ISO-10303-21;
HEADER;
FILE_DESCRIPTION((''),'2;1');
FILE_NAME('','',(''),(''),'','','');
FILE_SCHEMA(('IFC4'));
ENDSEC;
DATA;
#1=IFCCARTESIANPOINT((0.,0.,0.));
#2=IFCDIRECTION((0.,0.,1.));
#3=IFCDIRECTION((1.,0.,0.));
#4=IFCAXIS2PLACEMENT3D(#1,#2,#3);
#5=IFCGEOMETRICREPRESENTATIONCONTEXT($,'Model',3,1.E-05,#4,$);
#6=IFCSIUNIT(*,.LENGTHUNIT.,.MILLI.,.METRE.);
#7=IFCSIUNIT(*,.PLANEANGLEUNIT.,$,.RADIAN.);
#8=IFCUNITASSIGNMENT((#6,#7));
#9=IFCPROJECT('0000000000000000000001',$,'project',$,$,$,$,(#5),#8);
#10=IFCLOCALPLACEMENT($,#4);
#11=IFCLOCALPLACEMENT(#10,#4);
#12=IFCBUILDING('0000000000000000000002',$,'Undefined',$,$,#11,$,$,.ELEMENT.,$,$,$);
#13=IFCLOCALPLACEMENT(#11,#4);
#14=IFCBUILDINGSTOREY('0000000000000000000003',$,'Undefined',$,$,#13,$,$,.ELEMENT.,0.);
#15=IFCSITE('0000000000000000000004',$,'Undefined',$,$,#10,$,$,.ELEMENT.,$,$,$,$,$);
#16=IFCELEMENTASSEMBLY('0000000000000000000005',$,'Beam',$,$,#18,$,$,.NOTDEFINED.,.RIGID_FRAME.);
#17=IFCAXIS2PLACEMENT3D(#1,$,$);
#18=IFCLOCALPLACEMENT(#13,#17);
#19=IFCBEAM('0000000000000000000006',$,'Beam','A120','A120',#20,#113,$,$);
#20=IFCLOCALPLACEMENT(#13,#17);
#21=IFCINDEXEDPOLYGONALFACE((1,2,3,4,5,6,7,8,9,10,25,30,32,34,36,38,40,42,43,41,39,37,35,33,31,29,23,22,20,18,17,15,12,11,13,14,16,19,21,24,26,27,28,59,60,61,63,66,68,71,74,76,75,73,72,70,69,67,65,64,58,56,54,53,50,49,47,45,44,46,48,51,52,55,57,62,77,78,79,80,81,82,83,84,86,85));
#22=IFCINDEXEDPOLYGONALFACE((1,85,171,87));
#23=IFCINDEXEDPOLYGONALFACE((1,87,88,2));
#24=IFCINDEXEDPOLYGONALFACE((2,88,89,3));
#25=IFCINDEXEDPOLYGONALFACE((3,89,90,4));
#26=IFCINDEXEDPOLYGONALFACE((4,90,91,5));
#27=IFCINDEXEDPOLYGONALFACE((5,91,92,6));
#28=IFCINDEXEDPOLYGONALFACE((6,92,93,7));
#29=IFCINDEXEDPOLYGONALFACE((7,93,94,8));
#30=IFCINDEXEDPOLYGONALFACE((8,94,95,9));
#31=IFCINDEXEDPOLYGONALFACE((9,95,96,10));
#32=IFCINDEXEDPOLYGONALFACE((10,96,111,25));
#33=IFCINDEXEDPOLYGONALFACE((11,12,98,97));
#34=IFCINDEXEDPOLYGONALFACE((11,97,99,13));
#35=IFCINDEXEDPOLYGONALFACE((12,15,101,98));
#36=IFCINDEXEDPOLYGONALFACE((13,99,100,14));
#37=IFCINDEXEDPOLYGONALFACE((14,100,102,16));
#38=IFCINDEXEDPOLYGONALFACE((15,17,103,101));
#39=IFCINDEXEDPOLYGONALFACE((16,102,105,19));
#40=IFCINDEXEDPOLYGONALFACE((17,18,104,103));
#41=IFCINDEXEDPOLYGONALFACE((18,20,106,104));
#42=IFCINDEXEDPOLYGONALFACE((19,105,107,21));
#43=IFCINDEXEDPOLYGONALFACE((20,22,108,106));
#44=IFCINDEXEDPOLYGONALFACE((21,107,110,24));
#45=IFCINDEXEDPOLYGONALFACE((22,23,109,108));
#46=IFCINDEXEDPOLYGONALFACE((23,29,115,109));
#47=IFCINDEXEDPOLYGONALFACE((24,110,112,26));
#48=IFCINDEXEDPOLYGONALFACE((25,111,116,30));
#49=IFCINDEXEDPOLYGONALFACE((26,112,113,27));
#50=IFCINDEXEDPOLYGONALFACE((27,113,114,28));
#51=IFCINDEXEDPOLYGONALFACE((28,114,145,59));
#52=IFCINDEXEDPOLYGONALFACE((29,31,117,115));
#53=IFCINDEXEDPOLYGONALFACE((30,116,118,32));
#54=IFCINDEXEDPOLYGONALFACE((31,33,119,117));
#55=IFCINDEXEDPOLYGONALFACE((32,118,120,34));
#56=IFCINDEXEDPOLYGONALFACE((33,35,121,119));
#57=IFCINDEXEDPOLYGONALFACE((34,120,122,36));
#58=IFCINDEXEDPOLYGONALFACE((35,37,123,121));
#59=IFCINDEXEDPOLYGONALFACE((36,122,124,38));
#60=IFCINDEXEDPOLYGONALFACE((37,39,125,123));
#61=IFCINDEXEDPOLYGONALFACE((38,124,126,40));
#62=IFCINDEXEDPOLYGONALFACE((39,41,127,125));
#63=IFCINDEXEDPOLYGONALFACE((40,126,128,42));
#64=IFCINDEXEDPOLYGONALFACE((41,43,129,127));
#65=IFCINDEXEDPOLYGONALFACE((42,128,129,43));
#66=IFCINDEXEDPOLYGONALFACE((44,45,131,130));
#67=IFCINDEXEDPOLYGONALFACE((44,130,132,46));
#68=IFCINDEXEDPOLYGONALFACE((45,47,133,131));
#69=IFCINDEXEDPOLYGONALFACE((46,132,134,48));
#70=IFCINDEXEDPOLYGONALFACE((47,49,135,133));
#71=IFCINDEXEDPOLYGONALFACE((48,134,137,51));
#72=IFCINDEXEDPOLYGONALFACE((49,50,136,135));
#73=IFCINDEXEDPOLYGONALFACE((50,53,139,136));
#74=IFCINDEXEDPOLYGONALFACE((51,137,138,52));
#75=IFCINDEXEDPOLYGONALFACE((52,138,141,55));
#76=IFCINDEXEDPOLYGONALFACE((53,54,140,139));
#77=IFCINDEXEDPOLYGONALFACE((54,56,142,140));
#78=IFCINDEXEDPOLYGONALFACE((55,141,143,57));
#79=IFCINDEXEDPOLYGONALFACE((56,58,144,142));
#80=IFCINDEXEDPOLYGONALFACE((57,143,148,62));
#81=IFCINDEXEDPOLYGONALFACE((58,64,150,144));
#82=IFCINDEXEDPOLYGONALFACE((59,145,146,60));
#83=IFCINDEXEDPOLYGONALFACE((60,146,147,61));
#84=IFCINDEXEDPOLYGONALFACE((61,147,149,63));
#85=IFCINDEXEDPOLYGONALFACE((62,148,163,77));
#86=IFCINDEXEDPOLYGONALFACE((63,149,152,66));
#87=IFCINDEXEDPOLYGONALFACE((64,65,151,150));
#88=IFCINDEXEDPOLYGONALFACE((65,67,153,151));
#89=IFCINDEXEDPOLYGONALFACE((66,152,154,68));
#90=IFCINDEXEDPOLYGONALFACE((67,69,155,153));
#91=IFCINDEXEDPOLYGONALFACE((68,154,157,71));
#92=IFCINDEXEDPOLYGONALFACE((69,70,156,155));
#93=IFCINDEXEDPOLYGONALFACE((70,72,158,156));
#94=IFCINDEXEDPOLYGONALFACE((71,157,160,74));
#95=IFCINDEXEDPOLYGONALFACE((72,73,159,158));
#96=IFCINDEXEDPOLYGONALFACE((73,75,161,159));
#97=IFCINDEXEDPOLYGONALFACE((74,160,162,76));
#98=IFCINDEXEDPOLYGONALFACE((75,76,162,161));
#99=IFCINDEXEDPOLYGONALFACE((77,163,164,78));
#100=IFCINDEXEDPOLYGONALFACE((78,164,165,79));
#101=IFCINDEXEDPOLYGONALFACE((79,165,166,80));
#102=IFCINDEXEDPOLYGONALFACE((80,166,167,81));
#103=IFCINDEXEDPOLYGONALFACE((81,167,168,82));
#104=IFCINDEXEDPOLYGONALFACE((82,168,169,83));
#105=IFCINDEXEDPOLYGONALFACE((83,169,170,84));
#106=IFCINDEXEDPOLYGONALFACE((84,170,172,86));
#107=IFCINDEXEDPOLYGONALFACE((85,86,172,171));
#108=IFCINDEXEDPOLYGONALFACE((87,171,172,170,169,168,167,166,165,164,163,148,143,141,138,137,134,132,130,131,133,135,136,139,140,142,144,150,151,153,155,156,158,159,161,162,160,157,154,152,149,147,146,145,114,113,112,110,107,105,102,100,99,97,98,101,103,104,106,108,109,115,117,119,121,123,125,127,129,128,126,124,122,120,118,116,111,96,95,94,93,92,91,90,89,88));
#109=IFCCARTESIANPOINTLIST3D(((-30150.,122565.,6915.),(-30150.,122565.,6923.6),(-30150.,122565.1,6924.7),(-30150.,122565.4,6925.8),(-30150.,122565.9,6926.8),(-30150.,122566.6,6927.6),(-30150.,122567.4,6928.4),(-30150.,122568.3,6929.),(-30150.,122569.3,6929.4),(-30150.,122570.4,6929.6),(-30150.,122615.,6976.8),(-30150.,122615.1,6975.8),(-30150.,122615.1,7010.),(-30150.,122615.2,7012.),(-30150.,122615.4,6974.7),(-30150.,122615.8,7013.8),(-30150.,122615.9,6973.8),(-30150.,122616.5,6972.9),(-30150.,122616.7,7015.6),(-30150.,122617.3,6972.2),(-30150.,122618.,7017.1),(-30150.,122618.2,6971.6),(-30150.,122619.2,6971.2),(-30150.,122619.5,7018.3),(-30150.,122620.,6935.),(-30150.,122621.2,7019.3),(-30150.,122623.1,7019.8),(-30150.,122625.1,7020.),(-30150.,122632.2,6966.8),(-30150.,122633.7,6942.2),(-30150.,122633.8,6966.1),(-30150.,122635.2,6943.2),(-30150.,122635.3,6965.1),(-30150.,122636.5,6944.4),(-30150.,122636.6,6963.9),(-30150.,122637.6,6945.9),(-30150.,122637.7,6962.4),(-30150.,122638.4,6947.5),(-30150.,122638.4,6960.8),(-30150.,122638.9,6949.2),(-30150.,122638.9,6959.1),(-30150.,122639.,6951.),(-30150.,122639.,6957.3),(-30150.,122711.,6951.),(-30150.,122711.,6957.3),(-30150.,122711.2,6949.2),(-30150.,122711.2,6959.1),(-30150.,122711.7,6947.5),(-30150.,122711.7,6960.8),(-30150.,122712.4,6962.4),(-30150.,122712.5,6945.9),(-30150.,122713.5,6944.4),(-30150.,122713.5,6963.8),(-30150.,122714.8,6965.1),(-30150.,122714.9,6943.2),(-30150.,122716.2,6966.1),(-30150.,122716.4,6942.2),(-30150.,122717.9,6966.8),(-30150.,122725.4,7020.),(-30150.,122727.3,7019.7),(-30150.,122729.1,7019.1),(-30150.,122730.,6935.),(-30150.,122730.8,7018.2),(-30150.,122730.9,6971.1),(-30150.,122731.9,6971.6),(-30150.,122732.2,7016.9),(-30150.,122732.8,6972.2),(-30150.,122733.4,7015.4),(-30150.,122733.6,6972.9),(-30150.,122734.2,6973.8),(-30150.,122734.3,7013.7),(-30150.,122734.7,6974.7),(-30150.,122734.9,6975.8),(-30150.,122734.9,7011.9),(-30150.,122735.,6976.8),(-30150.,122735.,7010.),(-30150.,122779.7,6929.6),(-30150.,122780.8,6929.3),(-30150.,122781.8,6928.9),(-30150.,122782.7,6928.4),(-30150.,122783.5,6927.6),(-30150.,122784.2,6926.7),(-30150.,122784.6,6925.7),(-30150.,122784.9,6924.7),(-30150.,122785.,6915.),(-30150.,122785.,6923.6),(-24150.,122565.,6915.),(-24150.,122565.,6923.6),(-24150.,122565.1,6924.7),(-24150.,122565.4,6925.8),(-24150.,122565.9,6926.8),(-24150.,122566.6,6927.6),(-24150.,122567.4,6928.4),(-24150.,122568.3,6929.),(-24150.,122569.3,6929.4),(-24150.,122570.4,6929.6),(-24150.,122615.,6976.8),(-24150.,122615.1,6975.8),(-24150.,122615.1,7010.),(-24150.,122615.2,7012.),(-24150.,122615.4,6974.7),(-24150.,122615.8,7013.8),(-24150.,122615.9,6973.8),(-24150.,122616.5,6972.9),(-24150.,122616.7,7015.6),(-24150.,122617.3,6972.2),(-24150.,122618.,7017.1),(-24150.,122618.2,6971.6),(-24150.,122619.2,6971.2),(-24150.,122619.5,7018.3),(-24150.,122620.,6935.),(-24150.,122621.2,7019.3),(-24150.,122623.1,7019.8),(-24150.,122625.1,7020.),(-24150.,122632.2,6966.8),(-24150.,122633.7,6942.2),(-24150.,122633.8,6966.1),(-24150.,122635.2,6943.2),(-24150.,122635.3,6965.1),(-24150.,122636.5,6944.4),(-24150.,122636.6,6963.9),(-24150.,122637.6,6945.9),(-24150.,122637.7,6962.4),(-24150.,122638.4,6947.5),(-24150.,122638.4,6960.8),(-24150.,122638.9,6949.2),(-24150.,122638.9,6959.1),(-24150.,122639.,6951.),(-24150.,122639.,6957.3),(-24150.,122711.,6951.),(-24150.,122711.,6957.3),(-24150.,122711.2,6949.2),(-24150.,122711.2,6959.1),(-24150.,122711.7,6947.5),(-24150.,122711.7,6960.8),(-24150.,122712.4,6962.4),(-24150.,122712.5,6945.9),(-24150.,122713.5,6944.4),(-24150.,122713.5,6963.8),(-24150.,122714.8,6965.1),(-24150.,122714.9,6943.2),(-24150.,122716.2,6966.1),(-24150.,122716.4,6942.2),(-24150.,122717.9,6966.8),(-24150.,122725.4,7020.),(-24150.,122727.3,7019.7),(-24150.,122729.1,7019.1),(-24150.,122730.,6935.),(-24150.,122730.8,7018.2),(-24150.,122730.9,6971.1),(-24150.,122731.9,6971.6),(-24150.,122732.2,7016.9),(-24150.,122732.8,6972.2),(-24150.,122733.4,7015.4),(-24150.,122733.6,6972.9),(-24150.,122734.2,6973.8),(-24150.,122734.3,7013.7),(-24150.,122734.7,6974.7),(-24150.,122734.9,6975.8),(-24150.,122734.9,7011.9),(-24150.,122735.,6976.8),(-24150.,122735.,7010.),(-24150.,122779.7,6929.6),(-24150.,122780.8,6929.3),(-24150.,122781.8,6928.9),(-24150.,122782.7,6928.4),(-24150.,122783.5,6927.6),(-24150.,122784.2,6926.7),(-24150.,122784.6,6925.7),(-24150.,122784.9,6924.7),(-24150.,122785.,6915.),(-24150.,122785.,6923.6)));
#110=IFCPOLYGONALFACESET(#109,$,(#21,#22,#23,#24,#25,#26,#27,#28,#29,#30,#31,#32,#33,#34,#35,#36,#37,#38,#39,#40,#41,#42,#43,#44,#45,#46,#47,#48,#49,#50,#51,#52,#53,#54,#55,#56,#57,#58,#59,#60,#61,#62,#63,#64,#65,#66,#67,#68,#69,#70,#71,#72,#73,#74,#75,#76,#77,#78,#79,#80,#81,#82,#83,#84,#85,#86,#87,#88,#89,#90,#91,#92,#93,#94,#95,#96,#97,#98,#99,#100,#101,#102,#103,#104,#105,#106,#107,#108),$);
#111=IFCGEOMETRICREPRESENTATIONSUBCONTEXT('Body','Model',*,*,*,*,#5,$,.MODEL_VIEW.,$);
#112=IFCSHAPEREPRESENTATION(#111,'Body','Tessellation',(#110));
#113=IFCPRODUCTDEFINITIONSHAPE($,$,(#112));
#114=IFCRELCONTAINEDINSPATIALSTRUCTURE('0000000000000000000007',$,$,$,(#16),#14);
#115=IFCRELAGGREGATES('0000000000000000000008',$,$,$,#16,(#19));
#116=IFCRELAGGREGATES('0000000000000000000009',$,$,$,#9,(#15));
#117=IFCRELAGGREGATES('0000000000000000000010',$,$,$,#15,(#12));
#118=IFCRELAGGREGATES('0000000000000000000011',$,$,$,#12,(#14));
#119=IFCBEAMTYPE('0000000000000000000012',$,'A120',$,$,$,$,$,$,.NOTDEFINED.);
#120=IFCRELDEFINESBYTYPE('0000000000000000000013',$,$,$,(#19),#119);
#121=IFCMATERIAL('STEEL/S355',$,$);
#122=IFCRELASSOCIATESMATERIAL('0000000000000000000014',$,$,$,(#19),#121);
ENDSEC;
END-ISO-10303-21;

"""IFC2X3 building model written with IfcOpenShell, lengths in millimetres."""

from ifc_helpers import new_model, si_unit, frame, origin_with_axes, place, context, subcontext, project, spatial, polyline, outline, extrude, material, type_object, element, aggregate, save


model = new_model("IFC2X3")

# Units and contexts
model_context = context("Model", 3, precision=1e-05, world=origin_with_axes())
body_context = subcontext(model_context, "Body", "Model", "MODEL_VIEW")
ifc_project = project(units=[si_unit("LENGTHUNIT", "METRE", prefix="MILLI"), si_unit("PLANEANGLEUNIT", "RADIAN")], contexts=[model_context])

# Site, building, storey
site_placement = place(None, origin_with_axes())
site = spatial("IfcSite", under=ifc_project, at=site_placement, Name="Undefined", CompositionType="ELEMENT")
building_placement = place(site_placement, origin_with_axes())
building = spatial("IfcBuilding", under=site, at=building_placement, Name="Undefined", CompositionType="ELEMENT")
storey_placement = place(building_placement, origin_with_axes())
storey = spatial("IfcBuildingStorey", under=building, at=storey_placement, Name="Undefined", CompositionType="ELEMENT", Elevation=0.0)

# Element assembly, beam
ifc_material_1 = material(Name="STEEL/S355")
beam_type_1 = type_object("IfcBeamType", Name="A120", PredefinedType="NOTDEFINED")
assembly_1_placement = place(storey_placement, origin_with_axes())
assembly_1 = element("IfcElementAssembly", 1, at=assembly_1_placement, inside=storey, Name="Beam", AssemblyPlace="NOTDEFINED", PredefinedType="RIGID_FRAME")
beam_1_placement = place(assembly_1_placement, frame((-30150.0, 122675.0, 6967.5), z_axis=(0.0, 0.000118, 1.0), x_axis=(1.0, 0.0, 0.0)))
beam_1 = element("IfcBeam", 2, at=beam_1_placement, type_object=beam_type_1, material=ifc_material_1, Name="Beam", Description="A120", ObjectType="A120", context=body_context, shape_type="SweptSolid", body=[
    extrude(outline(polyline([(-110.0, -52.5), (-110.0, -43.9), (-109.9, -42.8), (-109.6, -41.8), (-109.1, -40.8), (-108.5, -39.9), (-107.7, -39.1), (-106.7, -38.6), (-105.7, -38.2), (-104.7, -37.9), (-55.0, -32.5), (-41.3, -25.3), (-39.8, -24.3), (-38.5, -23.1), (-37.4, -21.6), (-36.6, -20.0), (-36.2, -18.3), (-36.0, -16.5), (-36.0, -10.2), (-36.1, -8.4), (-36.6, -6.7), (-37.4, -5.1), (-38.4, -3.7), (-39.7, -2.4), (-41.2, -1.4), (-42.8, -0.7), (-55.9, 3.6), (-56.9, 4.1), (-57.8, 4.7), (-58.5, 5.4), (-59.2, 6.3), (-59.6, 7.2), (-59.9, 8.3), (-60.0, 9.3), (-60.0, 42.5), (-59.8, 44.4), (-59.3, 46.2), (-58.4, 47.9), (-57.2, 49.4), (-55.7, 50.7), (-54.1, 51.6), (-52.3, 52.2), (-50.4, 52.5), (50.0, 52.5), (51.9, 52.3), (53.8, 51.7), (55.5, 50.8), (57.1, 49.6), (58.3, 48.1), (59.2, 46.3), (59.8, 44.4), (60.0, 42.5), (60.0, 9.3), (59.9, 8.3), (59.6, 7.2), (59.2, 6.3), (58.5, 5.4), (57.8, 4.7), (56.9, 4.1), (55.9, 3.6), (42.8, -0.7), (41.2, -1.4), (39.7, -2.4), (38.4, -3.7), (37.4, -5.1), (36.6, -6.7), (36.1, -8.4), (36.0, -10.2), (36.0, -16.5), (36.2, -18.3), (36.6, -20.0), (37.4, -21.6), (38.5, -23.1), (39.8, -24.3), (41.3, -25.3), (55.0, -32.5), (104.7, -37.9), (105.7, -38.2), (106.7, -38.6), (107.7, -39.1), (108.5, -39.9), (109.1, -40.8), (109.6, -41.8), (109.9, -42.8), (110.0, -43.9), (110.0, -52.5), (-110.0, -52.5)])), frame((6000.0, 0.0, 0.0), z_axis=(-1.0, 0.0, 0.0), x_axis=(0.0, -1.0, 0.0)), (0.0, 0.0, 1.0), 6000.0),
])
aggregate(assembly_1, [beam_1])

save(model, "model.ifc")
